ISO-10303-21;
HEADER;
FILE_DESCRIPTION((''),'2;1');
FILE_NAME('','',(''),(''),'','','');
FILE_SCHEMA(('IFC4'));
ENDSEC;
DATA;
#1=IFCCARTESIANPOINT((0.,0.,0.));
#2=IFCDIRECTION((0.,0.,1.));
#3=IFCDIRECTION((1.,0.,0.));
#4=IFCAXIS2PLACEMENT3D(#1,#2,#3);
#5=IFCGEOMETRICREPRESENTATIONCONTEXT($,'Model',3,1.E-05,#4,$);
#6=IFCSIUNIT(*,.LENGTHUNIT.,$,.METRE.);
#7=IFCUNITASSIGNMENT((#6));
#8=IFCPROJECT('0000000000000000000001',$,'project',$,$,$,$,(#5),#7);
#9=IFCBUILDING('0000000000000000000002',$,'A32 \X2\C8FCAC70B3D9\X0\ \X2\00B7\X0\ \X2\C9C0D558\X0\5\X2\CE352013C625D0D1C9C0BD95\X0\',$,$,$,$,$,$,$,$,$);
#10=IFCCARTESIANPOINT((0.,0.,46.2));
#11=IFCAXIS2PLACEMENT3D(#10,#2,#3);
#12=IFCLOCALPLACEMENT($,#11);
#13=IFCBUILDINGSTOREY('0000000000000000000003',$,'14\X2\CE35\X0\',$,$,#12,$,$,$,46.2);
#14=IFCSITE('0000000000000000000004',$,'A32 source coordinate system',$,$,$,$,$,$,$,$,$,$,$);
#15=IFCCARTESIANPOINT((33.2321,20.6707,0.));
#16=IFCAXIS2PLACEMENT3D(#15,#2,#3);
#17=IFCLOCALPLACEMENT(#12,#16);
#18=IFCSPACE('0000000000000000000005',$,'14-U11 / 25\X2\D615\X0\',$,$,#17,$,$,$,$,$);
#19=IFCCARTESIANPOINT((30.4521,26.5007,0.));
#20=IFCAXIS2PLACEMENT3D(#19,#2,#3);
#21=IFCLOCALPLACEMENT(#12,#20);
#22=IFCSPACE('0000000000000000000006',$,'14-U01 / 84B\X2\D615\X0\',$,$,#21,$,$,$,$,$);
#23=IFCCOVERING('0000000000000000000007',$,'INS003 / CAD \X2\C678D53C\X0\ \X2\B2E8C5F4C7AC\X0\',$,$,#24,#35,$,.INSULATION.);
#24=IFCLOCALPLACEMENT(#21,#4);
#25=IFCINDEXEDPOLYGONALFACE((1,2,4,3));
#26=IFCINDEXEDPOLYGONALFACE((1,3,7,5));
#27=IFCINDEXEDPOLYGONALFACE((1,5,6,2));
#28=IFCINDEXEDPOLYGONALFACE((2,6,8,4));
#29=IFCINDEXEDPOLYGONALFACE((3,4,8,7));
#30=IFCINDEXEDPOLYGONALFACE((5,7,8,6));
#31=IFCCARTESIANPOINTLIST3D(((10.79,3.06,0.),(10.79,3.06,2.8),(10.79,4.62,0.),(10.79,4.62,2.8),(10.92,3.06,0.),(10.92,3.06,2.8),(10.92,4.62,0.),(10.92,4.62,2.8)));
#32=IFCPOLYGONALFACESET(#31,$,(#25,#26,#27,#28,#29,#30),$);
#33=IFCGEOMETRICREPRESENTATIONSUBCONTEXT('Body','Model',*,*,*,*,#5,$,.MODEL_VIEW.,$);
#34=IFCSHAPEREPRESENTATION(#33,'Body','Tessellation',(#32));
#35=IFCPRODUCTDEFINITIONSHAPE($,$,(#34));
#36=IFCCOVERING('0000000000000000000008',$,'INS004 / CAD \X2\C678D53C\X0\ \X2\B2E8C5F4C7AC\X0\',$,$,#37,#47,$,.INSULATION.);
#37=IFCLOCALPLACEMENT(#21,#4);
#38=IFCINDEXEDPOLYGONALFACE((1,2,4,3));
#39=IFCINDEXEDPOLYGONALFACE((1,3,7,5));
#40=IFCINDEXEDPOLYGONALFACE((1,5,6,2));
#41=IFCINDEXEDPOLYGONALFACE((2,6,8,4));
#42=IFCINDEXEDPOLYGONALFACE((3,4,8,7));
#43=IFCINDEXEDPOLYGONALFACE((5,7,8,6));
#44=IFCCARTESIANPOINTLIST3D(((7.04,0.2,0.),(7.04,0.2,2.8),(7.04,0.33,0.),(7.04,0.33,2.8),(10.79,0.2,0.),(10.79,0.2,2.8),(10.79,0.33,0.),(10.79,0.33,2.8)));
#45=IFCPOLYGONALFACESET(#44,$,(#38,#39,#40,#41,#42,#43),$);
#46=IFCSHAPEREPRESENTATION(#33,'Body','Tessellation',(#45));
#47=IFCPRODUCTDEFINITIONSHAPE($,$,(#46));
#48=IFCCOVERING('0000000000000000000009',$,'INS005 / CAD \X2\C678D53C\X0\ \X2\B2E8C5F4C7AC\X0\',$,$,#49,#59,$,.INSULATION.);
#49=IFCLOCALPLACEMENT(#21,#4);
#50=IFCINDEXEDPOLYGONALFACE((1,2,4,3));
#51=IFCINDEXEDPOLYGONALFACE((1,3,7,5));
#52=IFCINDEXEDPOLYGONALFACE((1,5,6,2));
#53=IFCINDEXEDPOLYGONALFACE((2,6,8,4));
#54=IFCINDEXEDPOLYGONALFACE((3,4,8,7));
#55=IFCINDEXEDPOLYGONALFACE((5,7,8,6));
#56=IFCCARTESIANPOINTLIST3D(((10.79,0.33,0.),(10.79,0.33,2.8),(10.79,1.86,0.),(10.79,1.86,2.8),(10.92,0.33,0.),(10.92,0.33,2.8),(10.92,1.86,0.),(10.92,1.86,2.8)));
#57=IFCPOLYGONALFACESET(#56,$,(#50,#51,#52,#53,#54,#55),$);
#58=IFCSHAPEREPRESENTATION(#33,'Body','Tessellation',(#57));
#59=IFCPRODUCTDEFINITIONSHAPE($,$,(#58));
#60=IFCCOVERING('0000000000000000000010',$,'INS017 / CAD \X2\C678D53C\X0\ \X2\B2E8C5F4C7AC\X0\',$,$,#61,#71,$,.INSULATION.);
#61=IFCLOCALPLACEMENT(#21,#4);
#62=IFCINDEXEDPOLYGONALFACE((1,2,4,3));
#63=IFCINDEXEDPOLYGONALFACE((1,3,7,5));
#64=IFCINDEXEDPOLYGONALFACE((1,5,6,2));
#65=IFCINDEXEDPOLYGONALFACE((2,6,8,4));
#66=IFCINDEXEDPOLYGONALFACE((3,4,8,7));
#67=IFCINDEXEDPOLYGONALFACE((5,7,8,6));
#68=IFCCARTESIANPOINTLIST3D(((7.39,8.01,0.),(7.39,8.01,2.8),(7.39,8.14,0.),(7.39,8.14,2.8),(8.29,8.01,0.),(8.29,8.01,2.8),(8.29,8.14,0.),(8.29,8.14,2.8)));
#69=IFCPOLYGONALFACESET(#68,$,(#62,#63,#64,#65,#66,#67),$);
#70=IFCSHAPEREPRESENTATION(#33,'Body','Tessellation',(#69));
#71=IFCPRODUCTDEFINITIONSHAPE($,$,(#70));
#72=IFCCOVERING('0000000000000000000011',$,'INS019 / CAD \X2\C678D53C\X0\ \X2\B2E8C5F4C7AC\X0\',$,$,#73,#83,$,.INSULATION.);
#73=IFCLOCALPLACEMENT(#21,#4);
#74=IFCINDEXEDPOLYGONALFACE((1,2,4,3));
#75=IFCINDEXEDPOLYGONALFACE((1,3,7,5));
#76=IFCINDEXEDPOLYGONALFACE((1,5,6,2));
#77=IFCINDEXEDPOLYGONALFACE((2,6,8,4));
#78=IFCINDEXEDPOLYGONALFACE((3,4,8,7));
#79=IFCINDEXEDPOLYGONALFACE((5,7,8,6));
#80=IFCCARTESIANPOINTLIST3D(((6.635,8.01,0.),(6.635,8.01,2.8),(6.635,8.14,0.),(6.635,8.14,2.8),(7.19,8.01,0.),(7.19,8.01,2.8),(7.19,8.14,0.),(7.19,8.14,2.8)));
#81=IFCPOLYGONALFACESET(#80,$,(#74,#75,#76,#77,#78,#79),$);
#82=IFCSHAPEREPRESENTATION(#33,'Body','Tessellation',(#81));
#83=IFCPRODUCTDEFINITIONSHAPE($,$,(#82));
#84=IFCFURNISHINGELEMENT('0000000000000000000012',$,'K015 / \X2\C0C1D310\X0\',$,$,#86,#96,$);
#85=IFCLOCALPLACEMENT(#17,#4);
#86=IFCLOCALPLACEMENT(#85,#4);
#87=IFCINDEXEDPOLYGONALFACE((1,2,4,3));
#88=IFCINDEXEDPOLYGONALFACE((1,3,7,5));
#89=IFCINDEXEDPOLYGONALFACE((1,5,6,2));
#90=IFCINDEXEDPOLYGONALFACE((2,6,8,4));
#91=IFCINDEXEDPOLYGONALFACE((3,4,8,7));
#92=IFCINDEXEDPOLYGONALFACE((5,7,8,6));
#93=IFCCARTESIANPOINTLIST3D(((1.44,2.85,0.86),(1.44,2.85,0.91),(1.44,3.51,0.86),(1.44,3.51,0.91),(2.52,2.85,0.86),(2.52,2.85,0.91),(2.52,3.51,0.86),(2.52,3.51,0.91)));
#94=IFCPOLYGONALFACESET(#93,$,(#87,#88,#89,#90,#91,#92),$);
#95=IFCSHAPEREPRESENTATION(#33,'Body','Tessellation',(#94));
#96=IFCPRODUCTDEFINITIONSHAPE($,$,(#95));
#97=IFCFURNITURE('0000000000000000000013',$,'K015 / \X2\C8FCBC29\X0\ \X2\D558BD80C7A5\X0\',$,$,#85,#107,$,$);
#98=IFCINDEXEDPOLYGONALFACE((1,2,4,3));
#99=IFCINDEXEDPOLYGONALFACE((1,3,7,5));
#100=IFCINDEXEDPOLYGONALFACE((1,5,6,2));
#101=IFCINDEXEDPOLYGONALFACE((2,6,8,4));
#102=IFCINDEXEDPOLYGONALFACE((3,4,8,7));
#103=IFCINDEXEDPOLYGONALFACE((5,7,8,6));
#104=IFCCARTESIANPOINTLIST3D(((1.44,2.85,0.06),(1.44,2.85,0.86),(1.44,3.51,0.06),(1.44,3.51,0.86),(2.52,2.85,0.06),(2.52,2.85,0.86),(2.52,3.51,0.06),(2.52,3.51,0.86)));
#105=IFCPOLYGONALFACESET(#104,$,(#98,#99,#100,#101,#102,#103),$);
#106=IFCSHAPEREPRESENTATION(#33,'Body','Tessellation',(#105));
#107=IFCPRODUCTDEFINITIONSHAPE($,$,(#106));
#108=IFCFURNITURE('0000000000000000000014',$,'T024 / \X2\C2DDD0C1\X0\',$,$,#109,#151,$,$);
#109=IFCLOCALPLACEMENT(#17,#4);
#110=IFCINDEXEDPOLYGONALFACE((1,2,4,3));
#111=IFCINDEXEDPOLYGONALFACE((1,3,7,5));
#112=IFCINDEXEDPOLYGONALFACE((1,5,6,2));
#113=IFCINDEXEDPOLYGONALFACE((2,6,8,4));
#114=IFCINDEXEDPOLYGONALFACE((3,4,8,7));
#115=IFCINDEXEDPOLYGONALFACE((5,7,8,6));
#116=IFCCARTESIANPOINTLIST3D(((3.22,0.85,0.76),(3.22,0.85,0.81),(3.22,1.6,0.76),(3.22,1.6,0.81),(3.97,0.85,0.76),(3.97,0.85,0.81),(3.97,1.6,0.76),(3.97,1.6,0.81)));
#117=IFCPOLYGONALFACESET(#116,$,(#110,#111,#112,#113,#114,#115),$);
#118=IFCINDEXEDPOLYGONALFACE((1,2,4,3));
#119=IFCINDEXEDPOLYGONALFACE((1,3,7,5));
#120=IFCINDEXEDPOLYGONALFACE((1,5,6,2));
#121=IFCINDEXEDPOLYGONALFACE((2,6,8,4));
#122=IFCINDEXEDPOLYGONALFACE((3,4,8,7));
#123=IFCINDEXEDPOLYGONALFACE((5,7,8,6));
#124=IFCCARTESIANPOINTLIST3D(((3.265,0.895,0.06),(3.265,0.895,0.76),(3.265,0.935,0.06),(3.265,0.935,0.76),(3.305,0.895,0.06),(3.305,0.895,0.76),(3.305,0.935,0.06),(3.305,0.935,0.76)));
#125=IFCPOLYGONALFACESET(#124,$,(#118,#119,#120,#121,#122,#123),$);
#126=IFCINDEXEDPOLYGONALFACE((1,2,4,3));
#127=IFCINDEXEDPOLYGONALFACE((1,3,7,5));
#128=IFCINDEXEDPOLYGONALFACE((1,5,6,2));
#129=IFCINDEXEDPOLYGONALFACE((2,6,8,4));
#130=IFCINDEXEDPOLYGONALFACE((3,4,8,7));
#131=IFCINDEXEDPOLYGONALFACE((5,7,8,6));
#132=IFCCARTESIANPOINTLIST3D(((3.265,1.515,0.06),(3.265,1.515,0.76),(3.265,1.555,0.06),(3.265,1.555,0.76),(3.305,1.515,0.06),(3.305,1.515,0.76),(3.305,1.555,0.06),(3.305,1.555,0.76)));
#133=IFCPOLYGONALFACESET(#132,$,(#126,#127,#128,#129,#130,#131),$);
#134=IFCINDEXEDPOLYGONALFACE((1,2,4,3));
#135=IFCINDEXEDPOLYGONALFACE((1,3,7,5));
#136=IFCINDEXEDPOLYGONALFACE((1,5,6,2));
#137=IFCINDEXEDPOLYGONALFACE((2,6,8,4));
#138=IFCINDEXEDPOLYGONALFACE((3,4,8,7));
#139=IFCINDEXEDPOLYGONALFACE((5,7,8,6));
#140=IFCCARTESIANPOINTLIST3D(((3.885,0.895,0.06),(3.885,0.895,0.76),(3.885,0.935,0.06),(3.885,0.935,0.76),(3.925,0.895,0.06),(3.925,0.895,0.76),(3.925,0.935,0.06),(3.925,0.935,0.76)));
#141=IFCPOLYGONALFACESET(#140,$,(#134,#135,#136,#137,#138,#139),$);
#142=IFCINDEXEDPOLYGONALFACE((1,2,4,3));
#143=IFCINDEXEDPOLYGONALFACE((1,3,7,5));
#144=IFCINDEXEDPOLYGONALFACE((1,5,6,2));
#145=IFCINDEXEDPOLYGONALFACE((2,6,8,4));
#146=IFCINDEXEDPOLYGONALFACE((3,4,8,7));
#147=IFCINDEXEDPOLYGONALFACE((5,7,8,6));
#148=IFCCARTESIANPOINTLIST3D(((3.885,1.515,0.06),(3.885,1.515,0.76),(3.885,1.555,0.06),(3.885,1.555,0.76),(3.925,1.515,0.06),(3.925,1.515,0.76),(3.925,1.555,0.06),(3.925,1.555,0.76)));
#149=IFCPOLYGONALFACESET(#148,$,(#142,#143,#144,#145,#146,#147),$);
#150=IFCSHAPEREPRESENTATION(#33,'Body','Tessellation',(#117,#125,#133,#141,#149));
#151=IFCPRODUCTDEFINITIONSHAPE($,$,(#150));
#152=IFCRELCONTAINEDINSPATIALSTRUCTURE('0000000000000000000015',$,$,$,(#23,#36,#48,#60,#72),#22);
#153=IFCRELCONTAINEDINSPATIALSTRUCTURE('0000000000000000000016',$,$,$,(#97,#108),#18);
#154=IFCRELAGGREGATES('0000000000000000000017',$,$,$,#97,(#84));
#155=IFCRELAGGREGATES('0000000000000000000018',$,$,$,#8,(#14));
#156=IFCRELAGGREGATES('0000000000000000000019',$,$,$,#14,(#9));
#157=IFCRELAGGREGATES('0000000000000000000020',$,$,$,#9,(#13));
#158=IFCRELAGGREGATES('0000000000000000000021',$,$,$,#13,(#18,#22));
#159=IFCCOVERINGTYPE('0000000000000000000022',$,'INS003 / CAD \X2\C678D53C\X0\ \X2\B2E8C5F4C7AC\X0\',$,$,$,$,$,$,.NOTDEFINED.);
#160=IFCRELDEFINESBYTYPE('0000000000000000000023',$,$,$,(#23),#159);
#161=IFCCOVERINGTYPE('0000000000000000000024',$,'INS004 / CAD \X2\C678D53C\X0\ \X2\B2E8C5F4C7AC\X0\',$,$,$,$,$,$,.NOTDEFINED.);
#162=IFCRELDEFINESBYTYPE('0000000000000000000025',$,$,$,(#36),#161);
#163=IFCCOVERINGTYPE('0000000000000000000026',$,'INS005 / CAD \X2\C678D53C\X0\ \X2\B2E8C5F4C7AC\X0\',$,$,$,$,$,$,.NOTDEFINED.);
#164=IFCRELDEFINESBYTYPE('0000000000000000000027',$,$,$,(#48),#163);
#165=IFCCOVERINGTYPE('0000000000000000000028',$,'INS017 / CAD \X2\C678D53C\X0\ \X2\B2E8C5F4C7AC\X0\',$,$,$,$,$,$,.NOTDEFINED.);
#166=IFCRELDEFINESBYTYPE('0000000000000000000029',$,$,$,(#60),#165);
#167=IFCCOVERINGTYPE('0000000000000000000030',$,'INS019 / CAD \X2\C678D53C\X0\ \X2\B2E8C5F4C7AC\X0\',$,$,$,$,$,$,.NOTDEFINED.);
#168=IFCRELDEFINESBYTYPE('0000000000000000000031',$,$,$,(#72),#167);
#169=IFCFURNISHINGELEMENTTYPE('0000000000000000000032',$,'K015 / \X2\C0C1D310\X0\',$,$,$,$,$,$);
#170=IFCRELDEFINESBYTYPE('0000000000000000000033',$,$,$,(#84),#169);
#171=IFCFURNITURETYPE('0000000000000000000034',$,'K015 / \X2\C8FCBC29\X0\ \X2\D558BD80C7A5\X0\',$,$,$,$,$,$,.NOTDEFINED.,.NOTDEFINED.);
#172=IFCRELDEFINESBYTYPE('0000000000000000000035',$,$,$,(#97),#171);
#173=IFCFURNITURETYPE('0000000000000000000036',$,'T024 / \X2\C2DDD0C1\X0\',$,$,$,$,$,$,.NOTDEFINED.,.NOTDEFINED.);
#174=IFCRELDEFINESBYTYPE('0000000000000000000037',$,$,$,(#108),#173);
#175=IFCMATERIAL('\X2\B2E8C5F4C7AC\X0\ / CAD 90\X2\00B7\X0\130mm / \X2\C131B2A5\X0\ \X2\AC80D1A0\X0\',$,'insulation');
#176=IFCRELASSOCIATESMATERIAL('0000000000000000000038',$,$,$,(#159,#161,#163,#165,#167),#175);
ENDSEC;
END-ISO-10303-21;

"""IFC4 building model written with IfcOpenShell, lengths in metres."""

from ifc_helpers import new_model, si_unit, frame, origin, origin_with_axes, place, context, subcontext, project, spatial, polyline, outline, extrude, source, transform, mapped, material, type_object, type_shapes, element, aggregate, save


model = new_model("IFC4")

# Units and contexts
model_context = context("Model", 3, precision=1e-05, world=origin_with_axes())
body_context = subcontext(model_context, "Body", "Model", "MODEL_VIEW")
ifc_project = project(units=[si_unit("LENGTHUNIT", "METRE")], contexts=[model_context])

# Site, building, storey, space
site = spatial("IfcSite", under=ifc_project, Name="A32 source coordinate system")
building = spatial("IfcBuilding", under=site, Name="A32 주거동 · 지하5층–옥탑지붕")
storey_placement = place(None, frame((0.0, 0.0, 46.2), z_axis=(0.0, 0.0, 1.0), x_axis=(1.0, 0.0, 0.0)))
storey = spatial("IfcBuildingStorey", under=building, at=storey_placement, Name="14층", Elevation=46.2)
space_1_placement = place(storey_placement, frame((33.2321, 20.6707, 0.0), z_axis=(0.0, 0.0, 1.0), x_axis=(1.0, 0.0, 0.0)))
space_1 = spatial("IfcSpace", under=storey, at=space_1_placement, Name="14-U11 / 25형")

# Shared definitions
space_2_placement = place(storey_placement, frame((30.4521, 26.5007, 0.0), z_axis=(0.0, 0.0, 1.0), x_axis=(1.0, 0.0, 0.0)))
space_2 = spatial("IfcSpace", under=storey, at=space_2_placement, Name="14-U01 / 84B형")

# Coverings
ifc_material = material(Name="단열재 / CAD 90·130mm / 성능 검토", Category="insulation")
covering_type_1 = type_object("IfcCoveringType", Name="INS003 / CAD 외피 단열재", PredefinedType="NOTDEFINED", material=ifc_material)
shared_shape_1 = source(origin(), body_context, "Body", "SweptSolid", [
    extrude(outline(polyline([(10.79, 3.06), (10.79, 4.62), (10.92, 4.62), (10.92, 3.06), (10.79, 3.06)])), origin(), (0.0, 0.0, 1.0), 2.8),
])
type_shapes(covering_type_1, [shared_shape_1])
covering_1_placement = place(space_2_placement, origin_with_axes())
element("IfcCovering", 1, at=covering_1_placement, inside=space_2, type_object=covering_type_1, Name="INS003 / CAD 외피 단열재", PredefinedType="INSULATION", context=body_context, shape_type="MappedRepresentation", body=[
    mapped(shared_shape_1, transform((0.0, 0.0, 0.0), scale=1.0)),
])
covering_type_2 = type_object("IfcCoveringType", Name="INS004 / CAD 외피 단열재", PredefinedType="NOTDEFINED", material=ifc_material)
shared_shape_2 = source(origin(), body_context, "Body", "SweptSolid", [
    extrude(outline(polyline([(7.04, 0.33), (10.79, 0.33), (10.79, 0.2), (7.04, 0.2), (7.04, 0.33)])), origin(), (0.0, 0.0, 1.0), 2.8),
])
type_shapes(covering_type_2, [shared_shape_2])
covering_2_placement = place(space_2_placement, origin_with_axes())
element("IfcCovering", 2, at=covering_2_placement, inside=space_2, type_object=covering_type_2, Name="INS004 / CAD 외피 단열재", PredefinedType="INSULATION", context=body_context, shape_type="MappedRepresentation", body=[
    mapped(shared_shape_2, transform((0.0, 0.0, 0.0), scale=1.0)),
])
covering_type_3 = type_object("IfcCoveringType", Name="INS005 / CAD 외피 단열재", PredefinedType="NOTDEFINED", material=ifc_material)
shared_shape_3 = source(origin(), body_context, "Body", "SweptSolid", [
    extrude(outline(polyline([(10.79, 0.33), (10.79, 1.86), (10.92, 1.86), (10.92, 0.33), (10.79, 0.33)])), origin(), (0.0, 0.0, 1.0), 2.8),
])
type_shapes(covering_type_3, [shared_shape_3])
covering_3_placement = place(space_2_placement, origin_with_axes())
element("IfcCovering", 3, at=covering_3_placement, inside=space_2, type_object=covering_type_3, Name="INS005 / CAD 외피 단열재", PredefinedType="INSULATION", context=body_context, shape_type="MappedRepresentation", body=[
    mapped(shared_shape_3, transform((0.0, 0.0, 0.0), scale=1.0)),
])
covering_type_4 = type_object("IfcCoveringType", Name="INS017 / CAD 외피 단열재", PredefinedType="NOTDEFINED", material=ifc_material)
shared_shape_4 = source(origin(), body_context, "Body", "SweptSolid", [
    extrude(outline(polyline([(8.29, 8.01), (7.39, 8.01), (7.39, 8.14), (8.29, 8.14), (8.29, 8.01)])), origin(), (0.0, 0.0, 1.0), 2.8),
])
type_shapes(covering_type_4, [shared_shape_4])
covering_4_placement = place(space_2_placement, origin_with_axes())
element("IfcCovering", 4, at=covering_4_placement, inside=space_2, type_object=covering_type_4, Name="INS017 / CAD 외피 단열재", PredefinedType="INSULATION", context=body_context, shape_type="MappedRepresentation", body=[
    mapped(shared_shape_4, transform((0.0, 0.0, 0.0), scale=1.0)),
])
covering_type_5 = type_object("IfcCoveringType", Name="INS019 / CAD 외피 단열재", PredefinedType="NOTDEFINED", material=ifc_material)
shared_shape_5 = source(origin(), body_context, "Body", "SweptSolid", [
    extrude(outline(polyline([(6.635, 8.01), (6.635, 8.14), (7.19, 8.14), (7.19, 8.01), (6.635, 8.01)])), origin(), (0.0, 0.0, 1.0), 2.8),
])
type_shapes(covering_type_5, [shared_shape_5])
covering_5_placement = place(space_2_placement, origin_with_axes())
element("IfcCovering", 5, at=covering_5_placement, inside=space_2, type_object=covering_type_5, Name="INS019 / CAD 외피 단열재", PredefinedType="INSULATION", context=body_context, shape_type="MappedRepresentation", body=[
    mapped(shared_shape_5, transform((0.0, 0.0, 0.0), scale=1.0)),
])

# Furnishing element
furnishing_element_type_1 = type_object("IfcFurnishingElementType", Name="K015 / 상판")
shared_shape_6 = source(origin(), body_context, "Body", "SweptSolid", [
    extrude(outline(polyline([(2.52, 2.85), (1.44, 2.85), (1.44, 3.51), (2.52, 3.51), (2.52, 2.85)])), frame((0.0, 0.0, 0.86)), (0.0, 0.0, 1.0), 0.05),
])
type_shapes(furnishing_element_type_1, [shared_shape_6])
furniture_1_placement = place(space_1_placement, origin_with_axes())
furnishing_1_placement = place(furniture_1_placement, origin_with_axes())
furnishing_1 = element("IfcFurnishingElement", 6, at=furnishing_1_placement, type_object=furnishing_element_type_1, Name="K015 / 상판", context=body_context, shape_type="MappedRepresentation", body=[
    mapped(shared_shape_6, transform((0.0, 0.0, 0.0), scale=1.0)),
])

# Furniture
furniture_type_1 = type_object("IfcFurnitureType", Name="K015 / 주방 하부장", AssemblyPlace="NOTDEFINED", PredefinedType="NOTDEFINED")
shared_shape_7 = source(origin(), body_context, "Body", "SweptSolid", [
    extrude(outline(polyline([(2.52, 3.51), (2.52, 2.85), (1.44, 2.85), (1.44, 3.51), (2.52, 3.51)])), frame((0.0, 0.0, 0.06)), (0.0, 0.0, 1.0), 0.8),
])
type_shapes(furniture_type_1, [shared_shape_7])
furniture_1 = element("IfcFurniture", 7, at=furniture_1_placement, inside=space_1, type_object=furniture_type_1, Name="K015 / 주방 하부장", context=body_context, shape_type="MappedRepresentation", body=[
    mapped(shared_shape_7, transform((0.0, 0.0, 0.0), scale=1.0)),
])
aggregate(furniture_1, [furnishing_1])
furniture_type_2 = type_object("IfcFurnitureType", Name="T024 / 식탁", AssemblyPlace="NOTDEFINED", PredefinedType="NOTDEFINED")
shared_shape_8 = source(origin(), body_context, "Body", "SweptSolid", [
    extrude(outline(polyline([(3.22, 0.85), (3.22, 1.6), (3.97, 1.6), (3.97, 0.85), (3.22, 0.85)])), frame((0.0, 0.0, 0.76)), (0.0, 0.0, 1.0), 0.05),
    extrude(outline(polyline([(3.265, 0.895), (3.265, 0.935), (3.305, 0.935), (3.305, 0.895), (3.265, 0.895)])), frame((0.0, 0.0, 0.06)), (0.0, 0.0, 1.0), 0.7),
    extrude(outline(polyline([(3.265, 1.515), (3.265, 1.555), (3.305, 1.555), (3.305, 1.515), (3.265, 1.515)])), frame((0.0, 0.0, 0.06)), (0.0, 0.0, 1.0), 0.7),
    extrude(outline(polyline([(3.885, 0.895), (3.885, 0.935), (3.925, 0.935), (3.925, 0.895), (3.885, 0.895)])), frame((0.0, 0.0, 0.06)), (0.0, 0.0, 1.0), 0.7),
    extrude(outline(polyline([(3.885, 1.515), (3.885, 1.555), (3.925, 1.555), (3.925, 1.515), (3.885, 1.515)])), frame((0.0, 0.0, 0.06)), (0.0, 0.0, 1.0), 0.7),
])
type_shapes(furniture_type_2, [shared_shape_8])
furniture_2_placement = place(space_1_placement, origin_with_axes())
element("IfcFurniture", 8, at=furniture_2_placement, inside=space_1, type_object=furniture_type_2, Name="T024 / 식탁", context=body_context, shape_type="MappedRepresentation", body=[
    mapped(shared_shape_8, transform((0.0, 0.0, 0.0), scale=1.0)),
])

save(model, "model.ifc")
